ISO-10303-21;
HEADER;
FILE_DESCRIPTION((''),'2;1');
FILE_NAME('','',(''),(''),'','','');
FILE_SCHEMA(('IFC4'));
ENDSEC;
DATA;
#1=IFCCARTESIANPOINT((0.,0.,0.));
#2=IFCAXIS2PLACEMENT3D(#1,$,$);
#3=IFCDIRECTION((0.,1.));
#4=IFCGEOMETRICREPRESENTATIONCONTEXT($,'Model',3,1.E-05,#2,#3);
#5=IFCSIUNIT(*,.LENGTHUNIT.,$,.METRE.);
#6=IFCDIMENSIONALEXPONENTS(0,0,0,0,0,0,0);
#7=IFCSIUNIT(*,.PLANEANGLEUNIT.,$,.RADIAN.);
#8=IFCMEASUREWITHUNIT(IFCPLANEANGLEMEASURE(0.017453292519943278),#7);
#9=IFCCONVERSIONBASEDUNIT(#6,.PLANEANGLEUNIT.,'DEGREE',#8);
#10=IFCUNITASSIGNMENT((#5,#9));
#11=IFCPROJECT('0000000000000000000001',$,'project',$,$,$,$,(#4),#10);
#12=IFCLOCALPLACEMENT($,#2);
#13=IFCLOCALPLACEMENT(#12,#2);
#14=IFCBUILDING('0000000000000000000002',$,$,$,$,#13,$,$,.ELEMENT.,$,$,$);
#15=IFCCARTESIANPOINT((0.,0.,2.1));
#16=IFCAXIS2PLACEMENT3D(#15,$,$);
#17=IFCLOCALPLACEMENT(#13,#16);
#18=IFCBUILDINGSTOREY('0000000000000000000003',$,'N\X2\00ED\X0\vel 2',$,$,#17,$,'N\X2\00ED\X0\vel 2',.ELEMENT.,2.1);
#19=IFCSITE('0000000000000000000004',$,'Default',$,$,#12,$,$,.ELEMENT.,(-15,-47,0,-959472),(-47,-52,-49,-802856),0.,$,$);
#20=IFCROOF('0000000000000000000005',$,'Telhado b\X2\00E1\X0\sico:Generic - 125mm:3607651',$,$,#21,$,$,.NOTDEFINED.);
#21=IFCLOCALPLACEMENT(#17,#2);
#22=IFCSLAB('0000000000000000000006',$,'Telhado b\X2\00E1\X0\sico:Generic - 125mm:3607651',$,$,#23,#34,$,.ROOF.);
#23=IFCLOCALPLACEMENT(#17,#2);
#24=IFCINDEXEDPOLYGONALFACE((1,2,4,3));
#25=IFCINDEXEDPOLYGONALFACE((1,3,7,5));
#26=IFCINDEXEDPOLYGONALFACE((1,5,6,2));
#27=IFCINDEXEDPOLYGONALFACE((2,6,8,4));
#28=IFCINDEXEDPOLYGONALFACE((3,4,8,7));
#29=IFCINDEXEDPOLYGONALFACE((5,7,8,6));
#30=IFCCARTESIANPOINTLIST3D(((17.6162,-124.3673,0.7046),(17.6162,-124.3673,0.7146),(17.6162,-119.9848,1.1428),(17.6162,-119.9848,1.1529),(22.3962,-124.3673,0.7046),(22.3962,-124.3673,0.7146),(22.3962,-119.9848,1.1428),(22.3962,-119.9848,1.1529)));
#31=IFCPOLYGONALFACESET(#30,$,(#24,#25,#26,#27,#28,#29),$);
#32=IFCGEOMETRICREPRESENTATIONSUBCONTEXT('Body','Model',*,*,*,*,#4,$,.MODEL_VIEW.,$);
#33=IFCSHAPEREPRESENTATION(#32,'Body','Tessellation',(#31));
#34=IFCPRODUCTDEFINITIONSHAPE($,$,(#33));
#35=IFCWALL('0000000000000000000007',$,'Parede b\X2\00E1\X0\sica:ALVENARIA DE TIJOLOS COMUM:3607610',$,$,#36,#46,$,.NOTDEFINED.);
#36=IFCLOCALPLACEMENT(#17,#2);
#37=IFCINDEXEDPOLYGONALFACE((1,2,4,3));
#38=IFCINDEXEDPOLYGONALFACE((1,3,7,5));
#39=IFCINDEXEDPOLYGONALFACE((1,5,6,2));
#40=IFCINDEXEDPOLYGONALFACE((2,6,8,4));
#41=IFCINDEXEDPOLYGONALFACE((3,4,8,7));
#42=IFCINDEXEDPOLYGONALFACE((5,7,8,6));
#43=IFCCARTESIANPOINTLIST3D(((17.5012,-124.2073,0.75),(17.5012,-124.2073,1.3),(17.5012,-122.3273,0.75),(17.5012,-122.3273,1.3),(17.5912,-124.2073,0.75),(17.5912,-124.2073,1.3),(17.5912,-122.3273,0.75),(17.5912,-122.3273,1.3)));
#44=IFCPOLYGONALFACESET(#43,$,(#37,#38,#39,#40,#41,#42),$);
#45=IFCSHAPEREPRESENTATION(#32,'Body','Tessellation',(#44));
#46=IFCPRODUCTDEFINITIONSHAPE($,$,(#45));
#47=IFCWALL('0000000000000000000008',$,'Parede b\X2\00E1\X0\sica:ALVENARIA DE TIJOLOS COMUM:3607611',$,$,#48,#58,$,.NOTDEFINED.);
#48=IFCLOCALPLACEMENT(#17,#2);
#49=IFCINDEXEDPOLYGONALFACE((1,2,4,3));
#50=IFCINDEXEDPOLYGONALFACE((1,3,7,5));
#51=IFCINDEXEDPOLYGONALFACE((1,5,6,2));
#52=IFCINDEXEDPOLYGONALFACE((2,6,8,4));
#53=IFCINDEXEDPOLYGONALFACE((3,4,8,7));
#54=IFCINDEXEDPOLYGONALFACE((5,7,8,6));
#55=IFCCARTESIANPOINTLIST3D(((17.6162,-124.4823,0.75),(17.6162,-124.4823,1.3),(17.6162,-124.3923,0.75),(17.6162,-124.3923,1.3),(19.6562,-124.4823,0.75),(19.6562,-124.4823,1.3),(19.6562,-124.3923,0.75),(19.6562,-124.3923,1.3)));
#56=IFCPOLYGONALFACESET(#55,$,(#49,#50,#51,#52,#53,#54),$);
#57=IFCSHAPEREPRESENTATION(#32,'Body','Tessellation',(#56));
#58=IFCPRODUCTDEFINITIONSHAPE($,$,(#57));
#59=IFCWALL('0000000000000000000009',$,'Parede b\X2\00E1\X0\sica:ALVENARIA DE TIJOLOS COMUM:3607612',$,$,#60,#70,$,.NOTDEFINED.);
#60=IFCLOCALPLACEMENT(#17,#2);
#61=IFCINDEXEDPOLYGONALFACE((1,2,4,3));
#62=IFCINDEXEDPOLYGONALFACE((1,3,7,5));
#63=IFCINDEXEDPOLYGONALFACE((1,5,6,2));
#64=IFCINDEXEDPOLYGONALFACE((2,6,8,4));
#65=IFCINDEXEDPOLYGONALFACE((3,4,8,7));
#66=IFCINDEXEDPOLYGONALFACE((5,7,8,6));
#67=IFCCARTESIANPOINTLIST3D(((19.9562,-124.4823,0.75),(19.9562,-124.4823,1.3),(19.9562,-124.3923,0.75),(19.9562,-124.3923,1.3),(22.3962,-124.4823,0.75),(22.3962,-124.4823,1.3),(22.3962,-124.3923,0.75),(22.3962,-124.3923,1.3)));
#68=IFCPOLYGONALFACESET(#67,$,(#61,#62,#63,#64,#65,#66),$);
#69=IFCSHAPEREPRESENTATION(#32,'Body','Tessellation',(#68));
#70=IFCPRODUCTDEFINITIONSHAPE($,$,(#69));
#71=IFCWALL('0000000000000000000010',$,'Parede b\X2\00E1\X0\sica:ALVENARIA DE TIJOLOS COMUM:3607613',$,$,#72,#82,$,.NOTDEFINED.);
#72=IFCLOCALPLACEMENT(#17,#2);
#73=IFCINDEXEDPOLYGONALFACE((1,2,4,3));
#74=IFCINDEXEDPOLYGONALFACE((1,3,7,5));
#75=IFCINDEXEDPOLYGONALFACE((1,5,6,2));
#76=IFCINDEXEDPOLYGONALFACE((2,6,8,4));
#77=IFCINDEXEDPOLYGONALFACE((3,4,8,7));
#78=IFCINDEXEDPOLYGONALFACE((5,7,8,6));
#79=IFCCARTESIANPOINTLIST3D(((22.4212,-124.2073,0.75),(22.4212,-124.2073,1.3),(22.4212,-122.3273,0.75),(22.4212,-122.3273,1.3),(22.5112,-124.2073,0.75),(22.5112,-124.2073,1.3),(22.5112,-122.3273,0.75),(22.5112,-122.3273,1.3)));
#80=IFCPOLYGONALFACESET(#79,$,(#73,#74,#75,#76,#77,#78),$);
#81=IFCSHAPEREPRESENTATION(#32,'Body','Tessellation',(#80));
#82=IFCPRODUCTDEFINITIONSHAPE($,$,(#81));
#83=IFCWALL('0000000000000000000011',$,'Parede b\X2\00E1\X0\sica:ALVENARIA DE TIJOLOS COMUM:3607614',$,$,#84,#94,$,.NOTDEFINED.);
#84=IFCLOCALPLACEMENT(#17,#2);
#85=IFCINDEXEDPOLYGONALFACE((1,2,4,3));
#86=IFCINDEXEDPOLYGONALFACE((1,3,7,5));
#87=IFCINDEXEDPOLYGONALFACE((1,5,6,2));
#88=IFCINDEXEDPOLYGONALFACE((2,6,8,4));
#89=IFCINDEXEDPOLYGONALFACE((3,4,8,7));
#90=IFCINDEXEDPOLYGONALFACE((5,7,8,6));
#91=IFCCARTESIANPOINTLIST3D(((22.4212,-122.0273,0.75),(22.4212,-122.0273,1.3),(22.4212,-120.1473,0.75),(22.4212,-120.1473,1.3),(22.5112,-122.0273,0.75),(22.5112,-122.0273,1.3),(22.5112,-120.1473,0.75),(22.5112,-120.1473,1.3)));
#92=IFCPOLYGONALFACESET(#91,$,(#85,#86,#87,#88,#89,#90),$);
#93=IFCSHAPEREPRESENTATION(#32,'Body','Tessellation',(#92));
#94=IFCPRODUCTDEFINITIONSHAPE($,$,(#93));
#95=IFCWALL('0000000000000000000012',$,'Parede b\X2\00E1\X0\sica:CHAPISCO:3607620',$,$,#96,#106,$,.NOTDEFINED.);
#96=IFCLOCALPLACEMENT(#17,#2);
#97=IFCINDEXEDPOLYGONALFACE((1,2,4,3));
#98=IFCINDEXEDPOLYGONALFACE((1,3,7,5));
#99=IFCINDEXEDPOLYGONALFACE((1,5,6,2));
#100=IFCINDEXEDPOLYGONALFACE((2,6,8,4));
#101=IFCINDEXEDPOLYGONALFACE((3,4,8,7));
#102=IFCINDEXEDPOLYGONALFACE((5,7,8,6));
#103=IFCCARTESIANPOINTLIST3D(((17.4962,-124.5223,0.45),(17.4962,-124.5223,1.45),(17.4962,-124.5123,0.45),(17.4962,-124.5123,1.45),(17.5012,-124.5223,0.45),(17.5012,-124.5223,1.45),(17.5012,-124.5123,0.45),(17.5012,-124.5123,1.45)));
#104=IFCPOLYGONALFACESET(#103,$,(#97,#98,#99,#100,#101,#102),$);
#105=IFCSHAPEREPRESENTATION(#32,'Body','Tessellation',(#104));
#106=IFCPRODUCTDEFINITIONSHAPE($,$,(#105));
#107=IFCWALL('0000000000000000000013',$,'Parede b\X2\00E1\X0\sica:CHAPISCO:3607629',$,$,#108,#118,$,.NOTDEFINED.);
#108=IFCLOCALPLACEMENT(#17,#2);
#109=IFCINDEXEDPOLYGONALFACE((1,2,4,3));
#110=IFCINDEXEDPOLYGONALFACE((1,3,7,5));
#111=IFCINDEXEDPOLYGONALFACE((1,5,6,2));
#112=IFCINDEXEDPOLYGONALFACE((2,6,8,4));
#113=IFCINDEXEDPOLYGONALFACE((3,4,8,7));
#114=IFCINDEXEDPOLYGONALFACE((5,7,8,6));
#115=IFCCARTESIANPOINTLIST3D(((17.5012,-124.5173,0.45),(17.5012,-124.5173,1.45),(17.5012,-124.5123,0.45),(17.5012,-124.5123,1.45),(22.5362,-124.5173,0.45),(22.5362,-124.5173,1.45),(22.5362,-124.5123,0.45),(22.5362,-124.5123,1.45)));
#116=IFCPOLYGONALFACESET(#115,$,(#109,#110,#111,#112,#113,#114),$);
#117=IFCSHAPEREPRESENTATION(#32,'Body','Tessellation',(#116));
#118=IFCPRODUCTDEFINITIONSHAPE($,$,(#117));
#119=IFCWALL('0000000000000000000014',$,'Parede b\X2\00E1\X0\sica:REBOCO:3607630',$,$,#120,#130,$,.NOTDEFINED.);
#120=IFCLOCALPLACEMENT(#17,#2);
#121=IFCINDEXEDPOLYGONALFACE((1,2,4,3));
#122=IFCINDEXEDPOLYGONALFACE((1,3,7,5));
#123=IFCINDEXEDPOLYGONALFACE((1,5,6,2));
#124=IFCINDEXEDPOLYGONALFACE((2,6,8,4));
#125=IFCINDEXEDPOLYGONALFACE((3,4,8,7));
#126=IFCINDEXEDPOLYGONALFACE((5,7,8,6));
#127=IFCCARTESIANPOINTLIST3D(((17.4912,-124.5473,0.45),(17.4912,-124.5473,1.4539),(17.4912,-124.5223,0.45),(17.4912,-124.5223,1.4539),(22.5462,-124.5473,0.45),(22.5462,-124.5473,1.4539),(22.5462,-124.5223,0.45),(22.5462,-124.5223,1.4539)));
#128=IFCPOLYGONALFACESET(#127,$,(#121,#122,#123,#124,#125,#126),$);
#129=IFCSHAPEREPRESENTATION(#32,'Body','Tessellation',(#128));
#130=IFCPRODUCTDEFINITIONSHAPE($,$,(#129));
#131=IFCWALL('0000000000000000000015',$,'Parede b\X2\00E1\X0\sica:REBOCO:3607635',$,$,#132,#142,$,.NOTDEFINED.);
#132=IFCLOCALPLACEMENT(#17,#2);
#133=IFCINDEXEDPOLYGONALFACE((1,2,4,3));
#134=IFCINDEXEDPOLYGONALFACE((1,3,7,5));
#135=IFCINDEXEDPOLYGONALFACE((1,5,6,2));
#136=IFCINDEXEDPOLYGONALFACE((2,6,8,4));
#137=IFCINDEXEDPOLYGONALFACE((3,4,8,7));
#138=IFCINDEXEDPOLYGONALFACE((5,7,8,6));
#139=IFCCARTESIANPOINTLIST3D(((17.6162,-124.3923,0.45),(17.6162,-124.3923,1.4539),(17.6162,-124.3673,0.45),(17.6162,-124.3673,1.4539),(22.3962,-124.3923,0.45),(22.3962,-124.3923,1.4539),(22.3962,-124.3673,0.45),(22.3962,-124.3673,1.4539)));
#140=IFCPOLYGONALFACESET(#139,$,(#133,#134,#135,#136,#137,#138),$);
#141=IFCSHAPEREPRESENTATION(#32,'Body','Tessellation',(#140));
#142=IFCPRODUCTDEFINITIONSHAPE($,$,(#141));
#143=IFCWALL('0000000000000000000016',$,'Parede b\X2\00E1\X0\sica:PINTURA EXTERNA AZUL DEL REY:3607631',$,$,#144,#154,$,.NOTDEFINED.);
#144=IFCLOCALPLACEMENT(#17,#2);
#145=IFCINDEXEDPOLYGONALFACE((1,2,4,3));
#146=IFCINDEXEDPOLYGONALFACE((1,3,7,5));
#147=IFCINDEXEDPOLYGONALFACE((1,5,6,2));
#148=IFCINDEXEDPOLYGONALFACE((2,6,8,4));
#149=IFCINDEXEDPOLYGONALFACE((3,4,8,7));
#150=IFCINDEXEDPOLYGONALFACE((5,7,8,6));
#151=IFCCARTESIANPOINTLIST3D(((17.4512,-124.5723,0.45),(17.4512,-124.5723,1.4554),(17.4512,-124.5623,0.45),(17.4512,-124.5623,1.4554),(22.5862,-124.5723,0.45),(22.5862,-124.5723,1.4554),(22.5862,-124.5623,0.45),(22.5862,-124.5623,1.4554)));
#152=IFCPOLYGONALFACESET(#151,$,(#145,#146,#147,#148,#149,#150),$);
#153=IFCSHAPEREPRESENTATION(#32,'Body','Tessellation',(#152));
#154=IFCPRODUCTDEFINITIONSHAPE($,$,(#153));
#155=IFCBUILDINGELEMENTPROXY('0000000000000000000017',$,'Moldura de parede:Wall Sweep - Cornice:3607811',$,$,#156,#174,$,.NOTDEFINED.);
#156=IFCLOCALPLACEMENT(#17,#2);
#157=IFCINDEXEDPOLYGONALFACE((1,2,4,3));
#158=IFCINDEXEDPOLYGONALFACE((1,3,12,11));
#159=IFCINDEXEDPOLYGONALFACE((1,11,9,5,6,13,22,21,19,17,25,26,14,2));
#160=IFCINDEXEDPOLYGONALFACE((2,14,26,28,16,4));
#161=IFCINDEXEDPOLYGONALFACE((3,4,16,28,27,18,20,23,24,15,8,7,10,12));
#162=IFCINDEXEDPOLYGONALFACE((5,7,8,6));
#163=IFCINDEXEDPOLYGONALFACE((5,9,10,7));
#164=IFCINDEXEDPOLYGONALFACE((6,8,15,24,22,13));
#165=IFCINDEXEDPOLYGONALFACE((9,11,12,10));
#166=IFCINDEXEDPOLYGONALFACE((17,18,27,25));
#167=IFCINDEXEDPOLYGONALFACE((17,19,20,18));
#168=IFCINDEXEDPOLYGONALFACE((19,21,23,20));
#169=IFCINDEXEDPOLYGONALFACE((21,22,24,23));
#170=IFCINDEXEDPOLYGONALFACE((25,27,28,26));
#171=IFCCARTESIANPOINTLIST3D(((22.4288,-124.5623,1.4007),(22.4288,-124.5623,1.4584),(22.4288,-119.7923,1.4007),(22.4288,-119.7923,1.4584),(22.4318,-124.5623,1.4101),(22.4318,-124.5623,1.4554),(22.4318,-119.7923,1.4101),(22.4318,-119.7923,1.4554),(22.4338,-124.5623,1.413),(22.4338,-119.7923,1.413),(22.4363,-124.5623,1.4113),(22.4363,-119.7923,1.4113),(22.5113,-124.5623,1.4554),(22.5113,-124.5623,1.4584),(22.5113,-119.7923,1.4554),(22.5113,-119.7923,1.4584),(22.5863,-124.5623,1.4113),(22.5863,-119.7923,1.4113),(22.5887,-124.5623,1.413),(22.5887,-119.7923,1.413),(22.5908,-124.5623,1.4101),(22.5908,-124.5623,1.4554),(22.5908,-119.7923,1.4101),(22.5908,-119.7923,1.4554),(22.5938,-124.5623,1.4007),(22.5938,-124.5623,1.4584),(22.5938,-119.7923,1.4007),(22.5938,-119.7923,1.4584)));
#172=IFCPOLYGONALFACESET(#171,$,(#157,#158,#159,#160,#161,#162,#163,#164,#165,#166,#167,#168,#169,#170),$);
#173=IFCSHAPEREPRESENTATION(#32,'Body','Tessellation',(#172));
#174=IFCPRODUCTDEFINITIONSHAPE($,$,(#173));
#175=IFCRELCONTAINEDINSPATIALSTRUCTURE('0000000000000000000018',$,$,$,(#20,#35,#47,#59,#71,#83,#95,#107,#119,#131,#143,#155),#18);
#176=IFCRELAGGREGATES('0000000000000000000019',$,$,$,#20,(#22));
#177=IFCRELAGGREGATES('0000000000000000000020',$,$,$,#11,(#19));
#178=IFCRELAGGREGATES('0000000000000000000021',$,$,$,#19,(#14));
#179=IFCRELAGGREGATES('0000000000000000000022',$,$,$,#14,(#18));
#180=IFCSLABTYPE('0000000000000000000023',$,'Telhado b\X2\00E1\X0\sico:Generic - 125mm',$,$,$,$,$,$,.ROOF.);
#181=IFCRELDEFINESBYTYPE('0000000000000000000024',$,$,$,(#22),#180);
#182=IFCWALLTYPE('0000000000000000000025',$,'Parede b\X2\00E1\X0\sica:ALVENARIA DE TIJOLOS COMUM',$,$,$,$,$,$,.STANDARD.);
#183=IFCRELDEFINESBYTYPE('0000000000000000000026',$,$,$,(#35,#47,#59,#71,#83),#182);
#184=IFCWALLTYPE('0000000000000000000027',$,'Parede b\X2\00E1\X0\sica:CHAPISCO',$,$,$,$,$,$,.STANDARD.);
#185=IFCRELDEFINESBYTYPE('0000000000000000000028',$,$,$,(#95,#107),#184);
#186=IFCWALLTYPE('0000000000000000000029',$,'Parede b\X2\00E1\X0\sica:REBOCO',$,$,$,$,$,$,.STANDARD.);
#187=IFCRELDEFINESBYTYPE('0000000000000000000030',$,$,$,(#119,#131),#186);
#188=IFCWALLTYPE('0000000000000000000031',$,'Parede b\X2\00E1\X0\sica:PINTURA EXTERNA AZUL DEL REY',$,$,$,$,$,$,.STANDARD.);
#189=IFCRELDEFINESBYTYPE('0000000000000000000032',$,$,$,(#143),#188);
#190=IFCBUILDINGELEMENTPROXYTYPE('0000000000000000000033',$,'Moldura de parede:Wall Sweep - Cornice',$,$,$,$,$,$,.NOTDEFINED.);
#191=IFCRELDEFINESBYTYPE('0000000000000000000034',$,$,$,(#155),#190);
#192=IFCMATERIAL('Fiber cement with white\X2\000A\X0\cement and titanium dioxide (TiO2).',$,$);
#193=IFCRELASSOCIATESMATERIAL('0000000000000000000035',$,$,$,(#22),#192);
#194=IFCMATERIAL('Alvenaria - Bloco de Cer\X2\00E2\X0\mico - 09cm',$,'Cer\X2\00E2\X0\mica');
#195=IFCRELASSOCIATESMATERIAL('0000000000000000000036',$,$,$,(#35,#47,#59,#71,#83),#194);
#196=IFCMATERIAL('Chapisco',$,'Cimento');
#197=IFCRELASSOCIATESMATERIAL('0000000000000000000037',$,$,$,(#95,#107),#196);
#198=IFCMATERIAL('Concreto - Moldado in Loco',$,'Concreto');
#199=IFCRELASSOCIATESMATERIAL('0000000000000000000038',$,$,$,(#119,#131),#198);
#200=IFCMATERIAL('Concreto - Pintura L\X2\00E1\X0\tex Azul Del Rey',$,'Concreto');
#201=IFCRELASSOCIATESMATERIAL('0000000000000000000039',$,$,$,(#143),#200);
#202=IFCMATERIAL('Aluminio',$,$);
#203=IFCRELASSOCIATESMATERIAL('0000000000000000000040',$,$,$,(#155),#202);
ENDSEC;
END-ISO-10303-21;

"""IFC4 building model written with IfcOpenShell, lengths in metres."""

from ifc_helpers import new_model, entity, si_unit, converted_unit, direction, frame, origin, place, context, subcontext, project, spatial, indexed_curve, outline, extrude, material, type_object, element, aggregate, save


model = new_model("IFC4")

# Units and contexts
model_context = context("Model", 3, precision=1e-05, world=origin(), true_north=direction((0.0, 1.0)))
body_context = subcontext(model_context, "Body", "Model", "MODEL_VIEW")
ifc_project = project(units=[si_unit("LENGTHUNIT", "METRE"), converted_unit("PLANEANGLEUNIT", "DEGREE", entity("IfcPlaneAngleMeasure", 0.017453292519943278), si_unit("PLANEANGLEUNIT", "RADIAN"), dimensions=[0, 0, 0, 0, 0, 0, 0])], contexts=[model_context])

# Site, building, storey
site_placement = place(None, origin())
site = spatial("IfcSite", under=ifc_project, at=site_placement, Name="Default", CompositionType="ELEMENT", RefLatitude=(-15, -47, 0, -959472), RefLongitude=(-47, -52, -49, -802856), RefElevation=0.0)
building_placement = place(site_placement, origin())
building = spatial("IfcBuilding", under=site, at=building_placement, CompositionType="ELEMENT")
storey_placement = place(building_placement, frame((0.0, 0.0, 2.1)))
storey = spatial("IfcBuildingStorey", under=building, at=storey_placement, Name="Nível 2", LongName="Nível 2", CompositionType="ELEMENT", Elevation=2.1)

# Roof, slab
roof_placement = place(storey_placement, frame((17.6162, -124.3673, 0.7046)))
roof = element("IfcRoof", 1, at=roof_placement, inside=storey, Name="Telhado básico:Generic - 125mm:3607651", PredefinedType="NOTDEFINED")
ifc_material_1 = material(Name="Fiber cement with white\ncement and titanium dioxide (TiO2).")
slab_type = type_object("IfcSlabType", Name="Telhado básico:Generic - 125mm", PredefinedType="ROOF")
slab_placement = place(roof_placement, origin())
slab = element("IfcSlab", 2, at=slab_placement, type_object=slab_type, material=ifc_material_1, Name="Telhado básico:Generic - 125mm:3607651", PredefinedType="ROOF", context=body_context, shape_type="SweptSolid", body=[
    extrude(outline(indexed_curve([(-2.39, 2.2022), (-2.39, -2.2022), (2.39, -2.2022), (2.39, 2.2022), (-2.39, 2.2022)], self_intersect=False)), frame((2.39, 2.1912, 0.2191), z_axis=(0.0, -0.099504, 0.995037), x_axis=(1.0, 0.0, 0.0)), (0.0, 0.099504, 0.995037), 0.01),
])
aggregate(roof, [slab])

# Walls
ifc_material_2 = material(Name="Alvenaria - Bloco de Cerâmico - 09cm", Category="Cerâmica")
wall_type_1 = type_object("IfcWallType", Name="Parede básica:ALVENARIA DE TIJOLOS COMUM", PredefinedType="STANDARD")
wall_1_placement = place(storey_placement, frame((17.5462, -122.3273, 0.75), z_axis=(0.0, 0.0, 1.0), x_axis=(0.0, -1.0, 0.0)))
element("IfcWall", 3, at=wall_1_placement, inside=storey, type_object=wall_type_1, material=ifc_material_2, Name="Parede básica:ALVENARIA DE TIJOLOS COMUM:3607610", PredefinedType="NOTDEFINED", context=body_context, shape_type="SweptSolid", body=[
    extrude(outline(indexed_curve([(1.88, 0.045), (0.0, 0.045), (0.0, -0.045), (1.88, -0.045), (1.88, 0.045)], self_intersect=False)), origin(), (0.0, 0.0, 1.0), 0.55),
])
wall_2_placement = place(storey_placement, frame((19.6562, -124.4373, 0.75), z_axis=(0.0, 0.0, 1.0), x_axis=(-1.0, 0.0, 0.0)))
element("IfcWall", 4, at=wall_2_placement, inside=storey, type_object=wall_type_1, material=ifc_material_2, Name="Parede básica:ALVENARIA DE TIJOLOS COMUM:3607611", PredefinedType="NOTDEFINED", context=body_context, shape_type="SweptSolid", body=[
    extrude(outline(indexed_curve([(2.04, 0.045), (0.0, 0.045), (0.0, -0.045), (2.04, -0.045), (2.04, 0.045)], self_intersect=False)), origin(), (0.0, 0.0, 1.0), 0.55),
])
wall_3_placement = place(storey_placement, frame((19.9562, -124.4373, 0.75)))
element("IfcWall", 5, at=wall_3_placement, inside=storey, type_object=wall_type_1, material=ifc_material_2, Name="Parede básica:ALVENARIA DE TIJOLOS COMUM:3607612", PredefinedType="NOTDEFINED", context=body_context, shape_type="SweptSolid", body=[
    extrude(outline(indexed_curve([(2.44, 0.045), (0.0, 0.045), (0.0, -0.045), (2.44, -0.045), (2.44, 0.045)], self_intersect=False)), origin(), (0.0, 0.0, 1.0), 0.55),
])
wall_4_placement = place(storey_placement, frame((22.4662, -122.3273, 0.75), z_axis=(0.0, 0.0, 1.0), x_axis=(0.0, -1.0, 0.0)))
element("IfcWall", 6, at=wall_4_placement, inside=storey, type_object=wall_type_1, material=ifc_material_2, Name="Parede básica:ALVENARIA DE TIJOLOS COMUM:3607613", PredefinedType="NOTDEFINED", context=body_context, shape_type="SweptSolid", body=[
    extrude(outline(indexed_curve([(1.88, 0.045), (0.0, 0.045), (0.0, -0.045), (1.88, -0.045), (1.88, 0.045)], self_intersect=False)), origin(), (0.0, 0.0, 1.0), 0.55),
])
wall_5_placement = place(storey_placement, frame((22.4662, -122.0273, 0.75), z_axis=(0.0, 0.0, 1.0), x_axis=(0.0, 1.0, 0.0)))
element("IfcWall", 7, at=wall_5_placement, inside=storey, type_object=wall_type_1, material=ifc_material_2, Name="Parede básica:ALVENARIA DE TIJOLOS COMUM:3607614", PredefinedType="NOTDEFINED", context=body_context, shape_type="SweptSolid", body=[
    extrude(outline(indexed_curve([(1.88, 0.045), (0.0, 0.045), (0.0, -0.045), (1.88, -0.045), (1.88, 0.045)], self_intersect=False)), origin(), (0.0, 0.0, 1.0), 0.55),
])
ifc_material_3 = material(Name="Chapisco", Category="Cimento")
wall_type_2 = type_object("IfcWallType", Name="Parede básica:CHAPISCO", PredefinedType="STANDARD")
wall_6_placement = place(storey_placement, frame((17.4987, -124.5123, 0.45), z_axis=(0.0, 0.0, 1.0), x_axis=(0.0, -1.0, 0.0)))
element("IfcWall", 8, at=wall_6_placement, inside=storey, type_object=wall_type_2, material=ifc_material_3, Name="Parede básica:CHAPISCO:3607620", PredefinedType="NOTDEFINED", context=body_context, shape_type="SweptSolid", body=[
    extrude(outline(indexed_curve([(0.01, 0.0025), (0.0, 0.0025), (0.0, -0.0025), (0.01, -0.0025), (0.01, 0.0025)], self_intersect=False)), origin(), (0.0, 0.0, 1.0), 1.0),
])
wall_7_placement = place(storey_placement, frame((17.5012, -124.5148, 0.45)))
element("IfcWall", 9, at=wall_7_placement, inside=storey, type_object=wall_type_2, material=ifc_material_3, Name="Parede básica:CHAPISCO:3607629", PredefinedType="NOTDEFINED", context=body_context, shape_type="SweptSolid", body=[
    extrude(outline(indexed_curve([(5.035, 0.0025), (0.0, 0.0025), (0.0, -0.0025), (5.035, -0.0025), (5.035, 0.0025)], self_intersect=False)), origin(), (0.0, 0.0, 1.0), 1.0),
])
ifc_material_4 = material(Name="Concreto - Moldado in Loco", Category="Concreto")
wall_type_3 = type_object("IfcWallType", Name="Parede básica:REBOCO", PredefinedType="STANDARD")
wall_8_placement = place(storey_placement, frame((17.4912, -124.5348, 0.45)))
element("IfcWall", 10, at=wall_8_placement, inside=storey, type_object=wall_type_3, material=ifc_material_4, Name="Parede básica:REBOCO:3607630", PredefinedType="NOTDEFINED", context=body_context, shape_type="SweptSolid", body=[
    extrude(outline(indexed_curve([(5.055, 0.0125), (0.0, 0.0125), (0.0, -0.0125), (5.055, -0.0125), (5.055, 0.0125)], self_intersect=False)), origin(), (0.0, 0.0, 1.0), 1.0039),
])
wall_9_placement = place(storey_placement, frame((17.6162, -124.3798, 0.45)))
element("IfcWall", 11, at=wall_9_placement, inside=storey, type_object=wall_type_3, material=ifc_material_4, Name="Parede básica:REBOCO:3607635", PredefinedType="NOTDEFINED", context=body_context, shape_type="SweptSolid", body=[
    extrude(outline(indexed_curve([(4.78, 0.0125), (0.0, 0.0125), (0.0, -0.0125), (4.78, -0.0125), (4.78, 0.0125)], self_intersect=False)), origin(), (0.0, 0.0, 1.0), 1.0039),
])
ifc_material_5 = material(Name="Concreto - Pintura Látex Azul Del Rey", Category="Concreto")
wall_type_4 = type_object("IfcWallType", Name="Parede básica:PINTURA EXTERNA AZUL DEL REY", PredefinedType="STANDARD")
wall_10_placement = place(storey_placement, frame((17.4512, -124.5673, 0.45)))
element("IfcWall", 12, at=wall_10_placement, inside=storey, type_object=wall_type_4, material=ifc_material_5, Name="Parede básica:PINTURA EXTERNA AZUL DEL REY:3607631", PredefinedType="NOTDEFINED", context=body_context, shape_type="SweptSolid", body=[
    extrude(outline(indexed_curve([(5.135, 0.005), (0.0, 0.005), (0.0, -0.005), (5.135, -0.005), (5.135, 0.005)], self_intersect=False)), origin(), (0.0, 0.0, 1.0), 1.0054),
])

# Building element proxy
ifc_material_6 = material(Name="Aluminio")
building_element_proxy_type_1 = type_object("IfcBuildingElementProxyType", Name="Moldura de parede:Wall Sweep - Cornice", PredefinedType="NOTDEFINED")
proxy_placement = place(storey_placement, frame((22.4288, -124.5623, 1.4007)))
element("IfcBuildingElementProxy", 13, at=proxy_placement, inside=storey, type_object=building_element_proxy_type_1, material=ifc_material_6, Name="Moldura de parede:Wall Sweep - Cornice:3607811", PredefinedType="NOTDEFINED", context=body_context, shape_type="SweptSolid", body=[
    extrude(outline(indexed_curve([(-0.029, -0.0825), (0.0287, -0.0825), (0.0181, -0.075), (0.0164, -0.0774), (0.0193, -0.0795), (-0.026, -0.0795), (-0.026, 0.0), (-0.026, 0.0795), (0.0193, 0.0795), (0.0164, 0.0774), (0.0181, 0.075), (0.0287, 0.0825), (-0.029, 0.0825), (-0.029, 0.0), (-0.029, -0.0825)], self_intersect=False)), frame((0.0825, 0.0, 0.0287), z_axis=(0.0, 1.0, 0.0), x_axis=(0.0, 0.0, -1.0)), (0.0, 0.0, 1.0), 4.77),
])

save(model, "model.ifc")
